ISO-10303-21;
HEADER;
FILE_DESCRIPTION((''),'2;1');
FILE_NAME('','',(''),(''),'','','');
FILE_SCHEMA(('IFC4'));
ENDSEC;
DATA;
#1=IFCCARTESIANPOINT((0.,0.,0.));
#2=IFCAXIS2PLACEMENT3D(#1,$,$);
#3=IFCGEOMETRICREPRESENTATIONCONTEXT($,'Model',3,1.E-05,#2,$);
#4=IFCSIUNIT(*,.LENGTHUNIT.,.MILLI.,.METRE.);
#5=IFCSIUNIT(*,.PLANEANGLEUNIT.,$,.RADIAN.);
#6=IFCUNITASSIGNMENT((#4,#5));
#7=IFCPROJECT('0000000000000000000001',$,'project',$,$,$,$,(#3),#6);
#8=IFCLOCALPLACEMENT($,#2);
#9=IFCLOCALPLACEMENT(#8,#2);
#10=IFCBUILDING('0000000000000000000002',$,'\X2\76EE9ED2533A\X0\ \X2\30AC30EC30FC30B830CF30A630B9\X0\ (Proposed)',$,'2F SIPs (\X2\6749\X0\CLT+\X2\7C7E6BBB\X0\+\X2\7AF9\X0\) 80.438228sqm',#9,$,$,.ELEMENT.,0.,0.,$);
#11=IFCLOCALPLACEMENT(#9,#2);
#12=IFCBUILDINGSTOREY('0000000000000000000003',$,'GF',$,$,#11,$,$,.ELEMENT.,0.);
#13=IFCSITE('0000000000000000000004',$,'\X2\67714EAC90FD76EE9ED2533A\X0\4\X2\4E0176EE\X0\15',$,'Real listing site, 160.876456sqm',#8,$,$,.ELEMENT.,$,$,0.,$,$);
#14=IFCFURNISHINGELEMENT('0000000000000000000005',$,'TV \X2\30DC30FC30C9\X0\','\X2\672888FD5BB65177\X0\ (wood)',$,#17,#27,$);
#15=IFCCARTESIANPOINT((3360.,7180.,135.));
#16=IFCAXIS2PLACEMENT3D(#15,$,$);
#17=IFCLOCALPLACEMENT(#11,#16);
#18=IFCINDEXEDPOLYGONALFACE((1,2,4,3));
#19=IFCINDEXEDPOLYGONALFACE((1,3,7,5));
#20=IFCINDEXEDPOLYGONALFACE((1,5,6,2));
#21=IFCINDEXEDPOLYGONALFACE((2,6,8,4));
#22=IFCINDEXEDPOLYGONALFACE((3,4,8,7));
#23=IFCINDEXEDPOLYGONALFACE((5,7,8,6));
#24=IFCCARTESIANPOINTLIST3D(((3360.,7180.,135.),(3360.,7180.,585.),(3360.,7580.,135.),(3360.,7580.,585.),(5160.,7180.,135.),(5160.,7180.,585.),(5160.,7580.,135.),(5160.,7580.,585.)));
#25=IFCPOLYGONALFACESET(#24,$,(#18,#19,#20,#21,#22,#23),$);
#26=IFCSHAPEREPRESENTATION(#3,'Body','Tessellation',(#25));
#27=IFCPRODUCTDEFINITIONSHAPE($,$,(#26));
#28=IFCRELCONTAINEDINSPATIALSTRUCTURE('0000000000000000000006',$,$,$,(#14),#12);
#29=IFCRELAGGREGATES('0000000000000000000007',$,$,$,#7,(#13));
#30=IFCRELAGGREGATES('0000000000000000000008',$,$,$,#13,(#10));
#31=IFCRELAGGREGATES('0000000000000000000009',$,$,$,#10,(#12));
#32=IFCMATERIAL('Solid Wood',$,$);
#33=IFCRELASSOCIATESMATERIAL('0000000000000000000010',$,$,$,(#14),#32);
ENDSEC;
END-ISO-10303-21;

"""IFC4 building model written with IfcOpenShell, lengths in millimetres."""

from ifc_helpers import new_model, si_unit, frame, frame_2d, origin, place, context, project, spatial, rectangle, extrude, material, element, save


model = new_model("IFC4")

# Units and contexts
model_context = context("Model", 3, precision=1e-05, world=origin())
ifc_project = project(units=[si_unit("LENGTHUNIT", "METRE", prefix="MILLI"), si_unit("PLANEANGLEUNIT", "RADIAN")], contexts=[model_context])

# Site, building, storey
site_placement = place(None, origin())
site = spatial("IfcSite", under=ifc_project, at=site_placement, Name="東京都目黒区4丁目15", ObjectType="Real listing site, 160.876456sqm", CompositionType="ELEMENT", RefElevation=0.0)
building_placement = place(site_placement, origin())
building = spatial("IfcBuilding", under=site, at=building_placement, Name="目黒区 ガレージハウス (Proposed)", ObjectType="2F SIPs (杉CLT+籾殻+竹) 80.438228sqm", CompositionType="ELEMENT", ElevationOfRefHeight=0.0, ElevationOfTerrain=0.0)
storey_placement = place(building_placement, origin())
storey = spatial("IfcBuildingStorey", under=building, at=storey_placement, Name="GF", CompositionType="ELEMENT", Elevation=0.0)

# Shared definitions
ifc_material_1 = material(Name="Solid Wood")

# Furnishing element
furnishing_1_placement = place(storey_placement, frame((3360.0, 7180.0, 135.0)))
element("IfcFurnishingElement", 1, at=furnishing_1_placement, inside=storey, material=ifc_material_1, Name="TV ボード", Description="木製家具 (wood)", context=model_context, shape_type="SweptSolid", body=[
    extrude(rectangle(XDim=1800.0, YDim=400.0, at=frame_2d((900.0, 200.0))), frame((3360.0, 7180.0, 135.0)), (0.0, 0.0, 1.0), 450.0),
])

save(model, "model.ifc")
